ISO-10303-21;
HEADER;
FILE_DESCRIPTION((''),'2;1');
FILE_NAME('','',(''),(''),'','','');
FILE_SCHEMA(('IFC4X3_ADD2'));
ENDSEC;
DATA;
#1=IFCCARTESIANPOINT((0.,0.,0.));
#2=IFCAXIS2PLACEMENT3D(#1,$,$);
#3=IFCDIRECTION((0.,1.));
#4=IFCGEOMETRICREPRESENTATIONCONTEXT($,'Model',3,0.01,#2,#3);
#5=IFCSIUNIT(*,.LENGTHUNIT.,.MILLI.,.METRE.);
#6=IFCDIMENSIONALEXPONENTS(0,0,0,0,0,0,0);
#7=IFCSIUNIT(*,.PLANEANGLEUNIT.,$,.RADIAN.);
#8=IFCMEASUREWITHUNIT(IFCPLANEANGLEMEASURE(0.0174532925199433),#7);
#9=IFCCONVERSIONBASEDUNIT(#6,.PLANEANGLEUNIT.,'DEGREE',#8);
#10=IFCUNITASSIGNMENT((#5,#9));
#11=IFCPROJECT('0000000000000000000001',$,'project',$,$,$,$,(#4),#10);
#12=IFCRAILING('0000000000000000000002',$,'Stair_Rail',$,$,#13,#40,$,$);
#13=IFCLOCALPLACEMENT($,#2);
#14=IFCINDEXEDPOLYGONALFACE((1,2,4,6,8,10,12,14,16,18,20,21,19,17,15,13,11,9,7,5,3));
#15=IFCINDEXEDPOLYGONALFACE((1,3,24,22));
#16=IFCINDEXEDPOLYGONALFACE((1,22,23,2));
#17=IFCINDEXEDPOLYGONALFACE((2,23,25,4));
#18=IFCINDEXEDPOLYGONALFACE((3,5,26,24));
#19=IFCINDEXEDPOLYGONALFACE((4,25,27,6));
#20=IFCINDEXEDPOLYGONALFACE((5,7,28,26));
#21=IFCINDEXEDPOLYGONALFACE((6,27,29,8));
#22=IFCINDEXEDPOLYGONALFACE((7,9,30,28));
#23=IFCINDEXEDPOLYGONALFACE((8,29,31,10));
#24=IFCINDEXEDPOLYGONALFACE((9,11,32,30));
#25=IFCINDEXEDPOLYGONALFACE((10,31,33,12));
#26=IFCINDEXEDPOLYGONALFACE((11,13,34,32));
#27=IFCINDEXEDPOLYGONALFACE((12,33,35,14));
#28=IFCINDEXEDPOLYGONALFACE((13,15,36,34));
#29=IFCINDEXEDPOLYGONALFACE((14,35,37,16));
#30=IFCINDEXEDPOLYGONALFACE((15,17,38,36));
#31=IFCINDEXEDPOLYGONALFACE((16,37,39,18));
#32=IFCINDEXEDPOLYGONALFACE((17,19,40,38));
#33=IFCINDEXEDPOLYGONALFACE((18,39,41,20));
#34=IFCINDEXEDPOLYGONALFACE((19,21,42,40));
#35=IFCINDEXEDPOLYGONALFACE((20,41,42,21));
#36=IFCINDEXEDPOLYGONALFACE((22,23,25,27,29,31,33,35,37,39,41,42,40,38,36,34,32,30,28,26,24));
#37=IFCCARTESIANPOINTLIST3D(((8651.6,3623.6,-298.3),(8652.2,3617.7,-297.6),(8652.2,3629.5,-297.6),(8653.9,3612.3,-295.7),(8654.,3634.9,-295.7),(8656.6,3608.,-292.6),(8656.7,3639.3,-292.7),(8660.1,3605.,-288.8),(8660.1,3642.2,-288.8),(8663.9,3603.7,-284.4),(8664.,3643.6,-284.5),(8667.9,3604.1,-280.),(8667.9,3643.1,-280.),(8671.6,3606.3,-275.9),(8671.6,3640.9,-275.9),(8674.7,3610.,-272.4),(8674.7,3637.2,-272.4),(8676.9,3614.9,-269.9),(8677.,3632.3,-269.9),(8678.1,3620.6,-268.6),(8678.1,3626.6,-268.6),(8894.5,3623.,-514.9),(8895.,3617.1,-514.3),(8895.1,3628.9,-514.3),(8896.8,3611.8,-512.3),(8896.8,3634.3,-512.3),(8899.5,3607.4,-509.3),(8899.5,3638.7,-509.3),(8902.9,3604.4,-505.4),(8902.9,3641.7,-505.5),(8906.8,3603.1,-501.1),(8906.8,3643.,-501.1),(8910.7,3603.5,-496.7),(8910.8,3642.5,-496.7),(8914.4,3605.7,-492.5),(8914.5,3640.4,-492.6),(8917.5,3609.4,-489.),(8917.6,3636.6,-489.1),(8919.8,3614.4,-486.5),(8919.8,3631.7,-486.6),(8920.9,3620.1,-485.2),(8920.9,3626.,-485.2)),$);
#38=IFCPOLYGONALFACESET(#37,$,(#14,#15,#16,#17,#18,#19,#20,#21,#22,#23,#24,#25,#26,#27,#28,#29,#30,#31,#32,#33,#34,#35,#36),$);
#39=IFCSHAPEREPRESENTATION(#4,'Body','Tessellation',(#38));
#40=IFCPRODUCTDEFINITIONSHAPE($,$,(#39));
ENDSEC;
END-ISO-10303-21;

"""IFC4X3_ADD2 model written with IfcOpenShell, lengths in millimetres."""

from ifc_helpers import new_model, entity, si_unit, converted_unit, direction, origin, context, project, element, save


model = new_model("IFC4X3_ADD2")

# Units and contexts
model_context = context("Model", 3, precision=0.01, world=origin(), true_north=direction((0.0, 1.0)))
ifc_project = project(units=[si_unit("LENGTHUNIT", "METRE", prefix="MILLI"), converted_unit("PLANEANGLEUNIT", "DEGREE", entity("IfcPlaneAngleMeasure", 0.0174532925199433), si_unit("PLANEANGLEUNIT", "RADIAN"), dimensions=[0, 0, 0, 0, 0, 0, 0])], contexts=[model_context])

# Railing
element("IfcRailing", 1, Name="Stair_Rail", context=model_context, shape_type="SweptSolid", body=[
    entity("IfcSweptDiskSolid", entity("IfcPolyline", [entity("IfcCartesianPoint", [8907.8, 3623.0, -500.0]), entity("IfcCartesianPoint", [8664.9, 3623.6, -283.3])]), 20.0),
])

save(model, "model.ifc")
